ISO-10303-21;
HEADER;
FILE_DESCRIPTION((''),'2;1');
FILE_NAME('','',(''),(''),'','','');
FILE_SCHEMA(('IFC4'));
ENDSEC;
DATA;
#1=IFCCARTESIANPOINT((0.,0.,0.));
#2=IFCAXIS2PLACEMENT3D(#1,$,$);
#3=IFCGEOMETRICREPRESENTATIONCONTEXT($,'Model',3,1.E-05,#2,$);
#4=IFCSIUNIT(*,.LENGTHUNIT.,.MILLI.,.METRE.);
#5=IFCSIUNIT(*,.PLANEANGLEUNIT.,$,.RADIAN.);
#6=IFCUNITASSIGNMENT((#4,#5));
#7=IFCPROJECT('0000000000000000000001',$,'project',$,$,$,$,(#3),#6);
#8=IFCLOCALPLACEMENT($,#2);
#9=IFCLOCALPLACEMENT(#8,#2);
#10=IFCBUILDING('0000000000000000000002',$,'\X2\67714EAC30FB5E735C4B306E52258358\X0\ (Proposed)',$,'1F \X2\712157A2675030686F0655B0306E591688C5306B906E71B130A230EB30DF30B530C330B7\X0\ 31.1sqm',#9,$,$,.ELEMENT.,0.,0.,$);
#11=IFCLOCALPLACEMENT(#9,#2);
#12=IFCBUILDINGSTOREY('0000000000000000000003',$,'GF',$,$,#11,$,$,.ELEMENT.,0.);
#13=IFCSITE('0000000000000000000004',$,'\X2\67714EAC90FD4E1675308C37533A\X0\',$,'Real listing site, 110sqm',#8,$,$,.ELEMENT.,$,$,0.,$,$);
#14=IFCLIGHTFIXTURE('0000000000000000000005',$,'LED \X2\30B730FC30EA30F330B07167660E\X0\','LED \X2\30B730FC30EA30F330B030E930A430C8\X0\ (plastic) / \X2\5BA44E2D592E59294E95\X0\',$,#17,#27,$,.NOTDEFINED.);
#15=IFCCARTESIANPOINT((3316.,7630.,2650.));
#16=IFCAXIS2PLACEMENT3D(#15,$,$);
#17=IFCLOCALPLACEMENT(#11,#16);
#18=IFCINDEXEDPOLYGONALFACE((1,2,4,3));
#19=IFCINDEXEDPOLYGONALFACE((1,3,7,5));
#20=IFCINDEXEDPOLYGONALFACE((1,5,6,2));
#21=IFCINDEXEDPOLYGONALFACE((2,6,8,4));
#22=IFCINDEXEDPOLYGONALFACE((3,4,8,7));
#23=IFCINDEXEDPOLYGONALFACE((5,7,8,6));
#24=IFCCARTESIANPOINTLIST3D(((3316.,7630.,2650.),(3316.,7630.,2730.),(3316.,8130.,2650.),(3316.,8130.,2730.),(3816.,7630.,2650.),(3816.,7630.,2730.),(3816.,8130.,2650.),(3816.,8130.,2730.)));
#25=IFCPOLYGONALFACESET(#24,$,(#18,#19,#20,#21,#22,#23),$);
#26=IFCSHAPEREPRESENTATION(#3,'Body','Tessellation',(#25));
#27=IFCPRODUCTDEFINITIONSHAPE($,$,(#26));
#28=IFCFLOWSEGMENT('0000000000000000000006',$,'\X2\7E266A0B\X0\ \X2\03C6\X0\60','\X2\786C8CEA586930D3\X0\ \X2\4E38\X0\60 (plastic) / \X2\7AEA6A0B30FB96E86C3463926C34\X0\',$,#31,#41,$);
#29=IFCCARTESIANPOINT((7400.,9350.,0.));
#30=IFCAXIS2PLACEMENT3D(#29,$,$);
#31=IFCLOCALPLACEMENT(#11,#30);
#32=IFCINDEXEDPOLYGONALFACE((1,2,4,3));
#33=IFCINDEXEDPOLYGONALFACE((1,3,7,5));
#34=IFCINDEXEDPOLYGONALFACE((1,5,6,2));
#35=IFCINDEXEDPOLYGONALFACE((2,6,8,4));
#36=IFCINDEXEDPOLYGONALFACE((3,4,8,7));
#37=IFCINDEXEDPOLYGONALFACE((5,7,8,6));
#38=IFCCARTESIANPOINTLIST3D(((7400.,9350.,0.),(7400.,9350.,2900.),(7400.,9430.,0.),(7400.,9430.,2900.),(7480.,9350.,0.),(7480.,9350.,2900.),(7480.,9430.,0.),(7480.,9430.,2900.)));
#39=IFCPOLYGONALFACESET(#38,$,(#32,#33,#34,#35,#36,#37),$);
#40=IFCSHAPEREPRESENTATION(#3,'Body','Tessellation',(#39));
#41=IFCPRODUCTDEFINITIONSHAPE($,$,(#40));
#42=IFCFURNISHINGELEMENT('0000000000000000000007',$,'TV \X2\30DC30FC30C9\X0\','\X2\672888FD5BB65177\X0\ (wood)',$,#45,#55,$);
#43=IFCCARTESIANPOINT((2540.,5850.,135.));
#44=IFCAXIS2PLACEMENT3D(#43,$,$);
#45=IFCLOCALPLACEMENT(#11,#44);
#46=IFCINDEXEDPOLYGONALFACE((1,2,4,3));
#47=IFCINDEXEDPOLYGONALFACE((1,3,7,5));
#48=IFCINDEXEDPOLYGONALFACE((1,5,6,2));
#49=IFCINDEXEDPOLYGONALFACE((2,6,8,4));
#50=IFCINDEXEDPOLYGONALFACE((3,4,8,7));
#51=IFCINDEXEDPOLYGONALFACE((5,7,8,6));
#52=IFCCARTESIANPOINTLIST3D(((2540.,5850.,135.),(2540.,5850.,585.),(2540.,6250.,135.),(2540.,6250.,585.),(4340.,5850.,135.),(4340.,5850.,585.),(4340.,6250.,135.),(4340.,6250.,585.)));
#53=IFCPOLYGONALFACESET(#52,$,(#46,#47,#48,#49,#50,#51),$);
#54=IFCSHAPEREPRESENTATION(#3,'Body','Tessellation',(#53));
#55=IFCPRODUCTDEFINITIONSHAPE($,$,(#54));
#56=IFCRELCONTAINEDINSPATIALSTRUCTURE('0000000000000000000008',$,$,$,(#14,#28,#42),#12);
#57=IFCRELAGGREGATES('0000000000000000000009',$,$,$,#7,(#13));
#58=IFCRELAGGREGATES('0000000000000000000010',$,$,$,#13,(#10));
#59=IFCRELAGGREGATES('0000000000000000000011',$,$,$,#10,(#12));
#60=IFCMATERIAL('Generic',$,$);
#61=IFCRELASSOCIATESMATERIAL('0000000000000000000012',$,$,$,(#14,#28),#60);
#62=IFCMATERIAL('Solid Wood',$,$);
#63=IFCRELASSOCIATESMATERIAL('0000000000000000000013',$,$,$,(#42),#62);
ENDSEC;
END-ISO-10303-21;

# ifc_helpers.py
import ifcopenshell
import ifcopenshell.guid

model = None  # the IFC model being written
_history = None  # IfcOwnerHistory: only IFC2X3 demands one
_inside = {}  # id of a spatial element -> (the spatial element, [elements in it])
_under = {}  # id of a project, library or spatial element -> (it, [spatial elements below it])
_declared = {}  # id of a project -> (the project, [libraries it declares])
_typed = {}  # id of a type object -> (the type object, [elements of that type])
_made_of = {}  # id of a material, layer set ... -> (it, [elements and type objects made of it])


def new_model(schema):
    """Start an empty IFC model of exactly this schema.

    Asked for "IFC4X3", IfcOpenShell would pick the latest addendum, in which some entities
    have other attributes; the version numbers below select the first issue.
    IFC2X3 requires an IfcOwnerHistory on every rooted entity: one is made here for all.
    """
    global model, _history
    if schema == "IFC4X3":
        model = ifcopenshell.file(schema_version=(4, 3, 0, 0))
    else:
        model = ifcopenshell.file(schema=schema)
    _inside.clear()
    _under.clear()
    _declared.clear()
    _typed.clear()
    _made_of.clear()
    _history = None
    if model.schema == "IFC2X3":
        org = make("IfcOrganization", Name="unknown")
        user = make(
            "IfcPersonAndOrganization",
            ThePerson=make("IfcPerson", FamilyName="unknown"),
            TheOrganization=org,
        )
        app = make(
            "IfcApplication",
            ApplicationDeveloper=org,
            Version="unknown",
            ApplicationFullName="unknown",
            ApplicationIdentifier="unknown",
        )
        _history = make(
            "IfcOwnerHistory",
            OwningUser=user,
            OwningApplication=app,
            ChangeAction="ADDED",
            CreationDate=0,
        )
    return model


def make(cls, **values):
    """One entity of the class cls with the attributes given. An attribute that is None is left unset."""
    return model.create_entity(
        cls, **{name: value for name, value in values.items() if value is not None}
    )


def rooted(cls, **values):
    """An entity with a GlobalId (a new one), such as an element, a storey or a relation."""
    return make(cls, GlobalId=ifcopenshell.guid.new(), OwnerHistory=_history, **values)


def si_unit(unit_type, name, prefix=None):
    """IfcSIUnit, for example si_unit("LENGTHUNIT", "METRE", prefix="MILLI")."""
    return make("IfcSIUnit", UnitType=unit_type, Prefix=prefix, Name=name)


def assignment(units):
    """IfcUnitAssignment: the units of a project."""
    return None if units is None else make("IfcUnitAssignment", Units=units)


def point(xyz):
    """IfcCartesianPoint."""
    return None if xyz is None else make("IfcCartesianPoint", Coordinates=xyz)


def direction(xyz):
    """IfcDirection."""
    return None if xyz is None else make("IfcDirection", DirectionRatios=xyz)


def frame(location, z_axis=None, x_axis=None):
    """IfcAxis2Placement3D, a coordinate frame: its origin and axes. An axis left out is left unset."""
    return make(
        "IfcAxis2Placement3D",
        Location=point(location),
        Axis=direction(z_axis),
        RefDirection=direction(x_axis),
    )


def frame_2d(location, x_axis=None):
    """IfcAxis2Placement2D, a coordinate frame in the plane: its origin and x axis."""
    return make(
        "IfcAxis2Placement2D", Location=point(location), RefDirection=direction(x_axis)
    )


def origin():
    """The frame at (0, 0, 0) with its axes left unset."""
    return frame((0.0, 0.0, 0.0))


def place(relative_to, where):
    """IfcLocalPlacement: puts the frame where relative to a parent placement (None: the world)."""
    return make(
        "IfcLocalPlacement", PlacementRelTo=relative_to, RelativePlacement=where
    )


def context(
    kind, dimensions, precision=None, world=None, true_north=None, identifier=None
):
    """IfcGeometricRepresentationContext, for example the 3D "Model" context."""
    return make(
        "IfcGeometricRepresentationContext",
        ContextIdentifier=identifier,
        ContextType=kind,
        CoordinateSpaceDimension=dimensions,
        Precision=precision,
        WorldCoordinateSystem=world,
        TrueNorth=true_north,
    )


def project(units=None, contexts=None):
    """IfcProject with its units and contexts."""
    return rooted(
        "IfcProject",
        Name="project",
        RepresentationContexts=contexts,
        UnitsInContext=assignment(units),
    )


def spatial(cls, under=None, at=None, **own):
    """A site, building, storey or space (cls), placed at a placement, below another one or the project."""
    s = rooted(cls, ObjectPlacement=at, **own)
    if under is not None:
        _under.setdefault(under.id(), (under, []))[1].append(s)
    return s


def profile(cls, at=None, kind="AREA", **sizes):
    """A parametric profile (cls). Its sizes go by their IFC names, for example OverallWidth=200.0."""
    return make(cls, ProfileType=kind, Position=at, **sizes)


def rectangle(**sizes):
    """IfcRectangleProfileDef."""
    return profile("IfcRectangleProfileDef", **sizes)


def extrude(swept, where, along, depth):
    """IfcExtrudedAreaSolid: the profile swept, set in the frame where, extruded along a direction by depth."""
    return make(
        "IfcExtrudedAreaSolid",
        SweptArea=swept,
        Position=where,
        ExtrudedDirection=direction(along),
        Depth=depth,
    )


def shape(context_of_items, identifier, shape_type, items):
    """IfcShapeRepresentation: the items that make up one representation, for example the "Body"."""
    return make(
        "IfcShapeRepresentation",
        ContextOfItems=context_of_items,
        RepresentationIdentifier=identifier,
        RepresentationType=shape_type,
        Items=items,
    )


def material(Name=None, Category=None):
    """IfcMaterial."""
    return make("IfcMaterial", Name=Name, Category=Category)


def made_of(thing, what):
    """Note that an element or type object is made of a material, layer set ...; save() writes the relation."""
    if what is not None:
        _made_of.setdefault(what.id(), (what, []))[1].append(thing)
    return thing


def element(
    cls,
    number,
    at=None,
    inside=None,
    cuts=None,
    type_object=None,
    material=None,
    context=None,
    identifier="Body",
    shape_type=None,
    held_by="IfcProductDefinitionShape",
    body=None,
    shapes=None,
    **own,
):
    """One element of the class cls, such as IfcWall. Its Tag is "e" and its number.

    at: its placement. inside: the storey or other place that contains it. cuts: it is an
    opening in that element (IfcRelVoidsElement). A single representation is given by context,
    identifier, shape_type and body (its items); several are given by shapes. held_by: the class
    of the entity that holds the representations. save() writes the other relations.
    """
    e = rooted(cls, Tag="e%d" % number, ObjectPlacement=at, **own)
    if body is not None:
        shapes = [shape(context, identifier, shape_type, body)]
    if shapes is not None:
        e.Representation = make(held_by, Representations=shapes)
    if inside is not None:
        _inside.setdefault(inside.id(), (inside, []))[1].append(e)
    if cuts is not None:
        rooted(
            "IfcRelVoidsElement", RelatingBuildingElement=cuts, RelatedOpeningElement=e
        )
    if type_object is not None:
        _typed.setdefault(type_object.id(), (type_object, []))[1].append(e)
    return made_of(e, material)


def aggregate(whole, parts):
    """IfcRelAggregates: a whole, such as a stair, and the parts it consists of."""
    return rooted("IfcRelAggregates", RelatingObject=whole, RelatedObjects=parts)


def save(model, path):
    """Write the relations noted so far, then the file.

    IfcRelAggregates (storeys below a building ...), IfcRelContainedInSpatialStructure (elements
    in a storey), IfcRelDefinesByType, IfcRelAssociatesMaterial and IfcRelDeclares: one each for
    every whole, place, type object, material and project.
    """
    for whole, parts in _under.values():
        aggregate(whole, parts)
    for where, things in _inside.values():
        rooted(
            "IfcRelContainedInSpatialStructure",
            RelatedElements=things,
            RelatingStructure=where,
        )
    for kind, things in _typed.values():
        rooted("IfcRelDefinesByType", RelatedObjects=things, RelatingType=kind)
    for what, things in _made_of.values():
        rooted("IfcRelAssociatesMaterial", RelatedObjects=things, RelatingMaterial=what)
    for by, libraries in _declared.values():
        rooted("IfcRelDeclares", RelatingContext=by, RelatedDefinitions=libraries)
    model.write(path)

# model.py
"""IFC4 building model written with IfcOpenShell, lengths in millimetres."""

from ifc_helpers import new_model, si_unit, frame, frame_2d, origin, place, context, project, spatial, rectangle, extrude, material, element, save


model = new_model("IFC4")

# Units and contexts
model_context = context("Model", 3, precision=1e-05, world=origin())
ifc_project = project(units=[si_unit("LENGTHUNIT", "METRE", prefix="MILLI"), si_unit("PLANEANGLEUNIT", "RADIAN")], contexts=[model_context])

# Site, building, storey
site_placement = place(None, origin())
site = spatial("IfcSite", under=ifc_project, at=site_placement, Name="東京都世田谷区", ObjectType="Real listing site, 110sqm", CompositionType="ELEMENT", RefElevation=0.0)
building_placement = place(site_placement, origin())
building = spatial("IfcBuilding", under=site, at=building_placement, Name="東京・平屋の別荘 (Proposed)", ObjectType="1F 無垢材と漆喰の外装に遮熱アルミサッシ 31.1sqm", CompositionType="ELEMENT", ElevationOfRefHeight=0.0, ElevationOfTerrain=0.0)
storey_placement = place(building_placement, origin())
storey = spatial("IfcBuildingStorey", under=building, at=storey_placement, Name="GF", CompositionType="ELEMENT", Elevation=0.0)

# Shared definitions
ifc_material_1 = material(Name="Solid Wood")

# Shared definitions
ifc_material_2 = material(Name="Generic")

# Light fixture
light_fixture_1_placement = place(storey_placement, frame((3316.0, 7630.0, 2650.0)))
element("IfcLightFixture", 1, at=light_fixture_1_placement, inside=storey, material=ifc_material_2, Name="LED シーリング照明", Description="LED シーリングライト (plastic) / 室中央天井", PredefinedType="NOTDEFINED", context=model_context, shape_type="SweptSolid", body=[
    extrude(rectangle(XDim=500.0, YDim=500.0, at=frame_2d((250.0, 250.0))), frame((3316.0, 7630.0, 2650.0)), (0.0, 0.0, 1.0), 80.0),
])

# Flow segment
flow_segment_placement = place(storey_placement, frame((7400.0, 9350.0, 0.0)))
element("IfcFlowSegment", 2, at=flow_segment_placement, inside=storey, material=ifc_material_2, Name="縦樋 φ60", Description="硬質塩ビ 丸60 (plastic) / 竪樋・雨水排水", context=model_context, shape_type="SweptSolid", body=[
    extrude(rectangle(XDim=80.0, YDim=80.0, at=frame_2d((40.0, 40.0))), frame((7400.0, 9350.0, 0.0)), (0.0, 0.0, 1.0), 2900.0),
])

# Furnishing element
furnishing_placement = place(storey_placement, frame((2540.0, 5850.0, 135.0)))
element("IfcFurnishingElement", 3, at=furnishing_placement, inside=storey, material=ifc_material_1, Name="TV ボード", Description="木製家具 (wood)", context=model_context, shape_type="SweptSolid", body=[
    extrude(rectangle(XDim=1800.0, YDim=400.0, at=frame_2d((900.0, 200.0))), frame((2540.0, 5850.0, 135.0)), (0.0, 0.0, 1.0), 450.0),
])

save(model, "model.ifc")
